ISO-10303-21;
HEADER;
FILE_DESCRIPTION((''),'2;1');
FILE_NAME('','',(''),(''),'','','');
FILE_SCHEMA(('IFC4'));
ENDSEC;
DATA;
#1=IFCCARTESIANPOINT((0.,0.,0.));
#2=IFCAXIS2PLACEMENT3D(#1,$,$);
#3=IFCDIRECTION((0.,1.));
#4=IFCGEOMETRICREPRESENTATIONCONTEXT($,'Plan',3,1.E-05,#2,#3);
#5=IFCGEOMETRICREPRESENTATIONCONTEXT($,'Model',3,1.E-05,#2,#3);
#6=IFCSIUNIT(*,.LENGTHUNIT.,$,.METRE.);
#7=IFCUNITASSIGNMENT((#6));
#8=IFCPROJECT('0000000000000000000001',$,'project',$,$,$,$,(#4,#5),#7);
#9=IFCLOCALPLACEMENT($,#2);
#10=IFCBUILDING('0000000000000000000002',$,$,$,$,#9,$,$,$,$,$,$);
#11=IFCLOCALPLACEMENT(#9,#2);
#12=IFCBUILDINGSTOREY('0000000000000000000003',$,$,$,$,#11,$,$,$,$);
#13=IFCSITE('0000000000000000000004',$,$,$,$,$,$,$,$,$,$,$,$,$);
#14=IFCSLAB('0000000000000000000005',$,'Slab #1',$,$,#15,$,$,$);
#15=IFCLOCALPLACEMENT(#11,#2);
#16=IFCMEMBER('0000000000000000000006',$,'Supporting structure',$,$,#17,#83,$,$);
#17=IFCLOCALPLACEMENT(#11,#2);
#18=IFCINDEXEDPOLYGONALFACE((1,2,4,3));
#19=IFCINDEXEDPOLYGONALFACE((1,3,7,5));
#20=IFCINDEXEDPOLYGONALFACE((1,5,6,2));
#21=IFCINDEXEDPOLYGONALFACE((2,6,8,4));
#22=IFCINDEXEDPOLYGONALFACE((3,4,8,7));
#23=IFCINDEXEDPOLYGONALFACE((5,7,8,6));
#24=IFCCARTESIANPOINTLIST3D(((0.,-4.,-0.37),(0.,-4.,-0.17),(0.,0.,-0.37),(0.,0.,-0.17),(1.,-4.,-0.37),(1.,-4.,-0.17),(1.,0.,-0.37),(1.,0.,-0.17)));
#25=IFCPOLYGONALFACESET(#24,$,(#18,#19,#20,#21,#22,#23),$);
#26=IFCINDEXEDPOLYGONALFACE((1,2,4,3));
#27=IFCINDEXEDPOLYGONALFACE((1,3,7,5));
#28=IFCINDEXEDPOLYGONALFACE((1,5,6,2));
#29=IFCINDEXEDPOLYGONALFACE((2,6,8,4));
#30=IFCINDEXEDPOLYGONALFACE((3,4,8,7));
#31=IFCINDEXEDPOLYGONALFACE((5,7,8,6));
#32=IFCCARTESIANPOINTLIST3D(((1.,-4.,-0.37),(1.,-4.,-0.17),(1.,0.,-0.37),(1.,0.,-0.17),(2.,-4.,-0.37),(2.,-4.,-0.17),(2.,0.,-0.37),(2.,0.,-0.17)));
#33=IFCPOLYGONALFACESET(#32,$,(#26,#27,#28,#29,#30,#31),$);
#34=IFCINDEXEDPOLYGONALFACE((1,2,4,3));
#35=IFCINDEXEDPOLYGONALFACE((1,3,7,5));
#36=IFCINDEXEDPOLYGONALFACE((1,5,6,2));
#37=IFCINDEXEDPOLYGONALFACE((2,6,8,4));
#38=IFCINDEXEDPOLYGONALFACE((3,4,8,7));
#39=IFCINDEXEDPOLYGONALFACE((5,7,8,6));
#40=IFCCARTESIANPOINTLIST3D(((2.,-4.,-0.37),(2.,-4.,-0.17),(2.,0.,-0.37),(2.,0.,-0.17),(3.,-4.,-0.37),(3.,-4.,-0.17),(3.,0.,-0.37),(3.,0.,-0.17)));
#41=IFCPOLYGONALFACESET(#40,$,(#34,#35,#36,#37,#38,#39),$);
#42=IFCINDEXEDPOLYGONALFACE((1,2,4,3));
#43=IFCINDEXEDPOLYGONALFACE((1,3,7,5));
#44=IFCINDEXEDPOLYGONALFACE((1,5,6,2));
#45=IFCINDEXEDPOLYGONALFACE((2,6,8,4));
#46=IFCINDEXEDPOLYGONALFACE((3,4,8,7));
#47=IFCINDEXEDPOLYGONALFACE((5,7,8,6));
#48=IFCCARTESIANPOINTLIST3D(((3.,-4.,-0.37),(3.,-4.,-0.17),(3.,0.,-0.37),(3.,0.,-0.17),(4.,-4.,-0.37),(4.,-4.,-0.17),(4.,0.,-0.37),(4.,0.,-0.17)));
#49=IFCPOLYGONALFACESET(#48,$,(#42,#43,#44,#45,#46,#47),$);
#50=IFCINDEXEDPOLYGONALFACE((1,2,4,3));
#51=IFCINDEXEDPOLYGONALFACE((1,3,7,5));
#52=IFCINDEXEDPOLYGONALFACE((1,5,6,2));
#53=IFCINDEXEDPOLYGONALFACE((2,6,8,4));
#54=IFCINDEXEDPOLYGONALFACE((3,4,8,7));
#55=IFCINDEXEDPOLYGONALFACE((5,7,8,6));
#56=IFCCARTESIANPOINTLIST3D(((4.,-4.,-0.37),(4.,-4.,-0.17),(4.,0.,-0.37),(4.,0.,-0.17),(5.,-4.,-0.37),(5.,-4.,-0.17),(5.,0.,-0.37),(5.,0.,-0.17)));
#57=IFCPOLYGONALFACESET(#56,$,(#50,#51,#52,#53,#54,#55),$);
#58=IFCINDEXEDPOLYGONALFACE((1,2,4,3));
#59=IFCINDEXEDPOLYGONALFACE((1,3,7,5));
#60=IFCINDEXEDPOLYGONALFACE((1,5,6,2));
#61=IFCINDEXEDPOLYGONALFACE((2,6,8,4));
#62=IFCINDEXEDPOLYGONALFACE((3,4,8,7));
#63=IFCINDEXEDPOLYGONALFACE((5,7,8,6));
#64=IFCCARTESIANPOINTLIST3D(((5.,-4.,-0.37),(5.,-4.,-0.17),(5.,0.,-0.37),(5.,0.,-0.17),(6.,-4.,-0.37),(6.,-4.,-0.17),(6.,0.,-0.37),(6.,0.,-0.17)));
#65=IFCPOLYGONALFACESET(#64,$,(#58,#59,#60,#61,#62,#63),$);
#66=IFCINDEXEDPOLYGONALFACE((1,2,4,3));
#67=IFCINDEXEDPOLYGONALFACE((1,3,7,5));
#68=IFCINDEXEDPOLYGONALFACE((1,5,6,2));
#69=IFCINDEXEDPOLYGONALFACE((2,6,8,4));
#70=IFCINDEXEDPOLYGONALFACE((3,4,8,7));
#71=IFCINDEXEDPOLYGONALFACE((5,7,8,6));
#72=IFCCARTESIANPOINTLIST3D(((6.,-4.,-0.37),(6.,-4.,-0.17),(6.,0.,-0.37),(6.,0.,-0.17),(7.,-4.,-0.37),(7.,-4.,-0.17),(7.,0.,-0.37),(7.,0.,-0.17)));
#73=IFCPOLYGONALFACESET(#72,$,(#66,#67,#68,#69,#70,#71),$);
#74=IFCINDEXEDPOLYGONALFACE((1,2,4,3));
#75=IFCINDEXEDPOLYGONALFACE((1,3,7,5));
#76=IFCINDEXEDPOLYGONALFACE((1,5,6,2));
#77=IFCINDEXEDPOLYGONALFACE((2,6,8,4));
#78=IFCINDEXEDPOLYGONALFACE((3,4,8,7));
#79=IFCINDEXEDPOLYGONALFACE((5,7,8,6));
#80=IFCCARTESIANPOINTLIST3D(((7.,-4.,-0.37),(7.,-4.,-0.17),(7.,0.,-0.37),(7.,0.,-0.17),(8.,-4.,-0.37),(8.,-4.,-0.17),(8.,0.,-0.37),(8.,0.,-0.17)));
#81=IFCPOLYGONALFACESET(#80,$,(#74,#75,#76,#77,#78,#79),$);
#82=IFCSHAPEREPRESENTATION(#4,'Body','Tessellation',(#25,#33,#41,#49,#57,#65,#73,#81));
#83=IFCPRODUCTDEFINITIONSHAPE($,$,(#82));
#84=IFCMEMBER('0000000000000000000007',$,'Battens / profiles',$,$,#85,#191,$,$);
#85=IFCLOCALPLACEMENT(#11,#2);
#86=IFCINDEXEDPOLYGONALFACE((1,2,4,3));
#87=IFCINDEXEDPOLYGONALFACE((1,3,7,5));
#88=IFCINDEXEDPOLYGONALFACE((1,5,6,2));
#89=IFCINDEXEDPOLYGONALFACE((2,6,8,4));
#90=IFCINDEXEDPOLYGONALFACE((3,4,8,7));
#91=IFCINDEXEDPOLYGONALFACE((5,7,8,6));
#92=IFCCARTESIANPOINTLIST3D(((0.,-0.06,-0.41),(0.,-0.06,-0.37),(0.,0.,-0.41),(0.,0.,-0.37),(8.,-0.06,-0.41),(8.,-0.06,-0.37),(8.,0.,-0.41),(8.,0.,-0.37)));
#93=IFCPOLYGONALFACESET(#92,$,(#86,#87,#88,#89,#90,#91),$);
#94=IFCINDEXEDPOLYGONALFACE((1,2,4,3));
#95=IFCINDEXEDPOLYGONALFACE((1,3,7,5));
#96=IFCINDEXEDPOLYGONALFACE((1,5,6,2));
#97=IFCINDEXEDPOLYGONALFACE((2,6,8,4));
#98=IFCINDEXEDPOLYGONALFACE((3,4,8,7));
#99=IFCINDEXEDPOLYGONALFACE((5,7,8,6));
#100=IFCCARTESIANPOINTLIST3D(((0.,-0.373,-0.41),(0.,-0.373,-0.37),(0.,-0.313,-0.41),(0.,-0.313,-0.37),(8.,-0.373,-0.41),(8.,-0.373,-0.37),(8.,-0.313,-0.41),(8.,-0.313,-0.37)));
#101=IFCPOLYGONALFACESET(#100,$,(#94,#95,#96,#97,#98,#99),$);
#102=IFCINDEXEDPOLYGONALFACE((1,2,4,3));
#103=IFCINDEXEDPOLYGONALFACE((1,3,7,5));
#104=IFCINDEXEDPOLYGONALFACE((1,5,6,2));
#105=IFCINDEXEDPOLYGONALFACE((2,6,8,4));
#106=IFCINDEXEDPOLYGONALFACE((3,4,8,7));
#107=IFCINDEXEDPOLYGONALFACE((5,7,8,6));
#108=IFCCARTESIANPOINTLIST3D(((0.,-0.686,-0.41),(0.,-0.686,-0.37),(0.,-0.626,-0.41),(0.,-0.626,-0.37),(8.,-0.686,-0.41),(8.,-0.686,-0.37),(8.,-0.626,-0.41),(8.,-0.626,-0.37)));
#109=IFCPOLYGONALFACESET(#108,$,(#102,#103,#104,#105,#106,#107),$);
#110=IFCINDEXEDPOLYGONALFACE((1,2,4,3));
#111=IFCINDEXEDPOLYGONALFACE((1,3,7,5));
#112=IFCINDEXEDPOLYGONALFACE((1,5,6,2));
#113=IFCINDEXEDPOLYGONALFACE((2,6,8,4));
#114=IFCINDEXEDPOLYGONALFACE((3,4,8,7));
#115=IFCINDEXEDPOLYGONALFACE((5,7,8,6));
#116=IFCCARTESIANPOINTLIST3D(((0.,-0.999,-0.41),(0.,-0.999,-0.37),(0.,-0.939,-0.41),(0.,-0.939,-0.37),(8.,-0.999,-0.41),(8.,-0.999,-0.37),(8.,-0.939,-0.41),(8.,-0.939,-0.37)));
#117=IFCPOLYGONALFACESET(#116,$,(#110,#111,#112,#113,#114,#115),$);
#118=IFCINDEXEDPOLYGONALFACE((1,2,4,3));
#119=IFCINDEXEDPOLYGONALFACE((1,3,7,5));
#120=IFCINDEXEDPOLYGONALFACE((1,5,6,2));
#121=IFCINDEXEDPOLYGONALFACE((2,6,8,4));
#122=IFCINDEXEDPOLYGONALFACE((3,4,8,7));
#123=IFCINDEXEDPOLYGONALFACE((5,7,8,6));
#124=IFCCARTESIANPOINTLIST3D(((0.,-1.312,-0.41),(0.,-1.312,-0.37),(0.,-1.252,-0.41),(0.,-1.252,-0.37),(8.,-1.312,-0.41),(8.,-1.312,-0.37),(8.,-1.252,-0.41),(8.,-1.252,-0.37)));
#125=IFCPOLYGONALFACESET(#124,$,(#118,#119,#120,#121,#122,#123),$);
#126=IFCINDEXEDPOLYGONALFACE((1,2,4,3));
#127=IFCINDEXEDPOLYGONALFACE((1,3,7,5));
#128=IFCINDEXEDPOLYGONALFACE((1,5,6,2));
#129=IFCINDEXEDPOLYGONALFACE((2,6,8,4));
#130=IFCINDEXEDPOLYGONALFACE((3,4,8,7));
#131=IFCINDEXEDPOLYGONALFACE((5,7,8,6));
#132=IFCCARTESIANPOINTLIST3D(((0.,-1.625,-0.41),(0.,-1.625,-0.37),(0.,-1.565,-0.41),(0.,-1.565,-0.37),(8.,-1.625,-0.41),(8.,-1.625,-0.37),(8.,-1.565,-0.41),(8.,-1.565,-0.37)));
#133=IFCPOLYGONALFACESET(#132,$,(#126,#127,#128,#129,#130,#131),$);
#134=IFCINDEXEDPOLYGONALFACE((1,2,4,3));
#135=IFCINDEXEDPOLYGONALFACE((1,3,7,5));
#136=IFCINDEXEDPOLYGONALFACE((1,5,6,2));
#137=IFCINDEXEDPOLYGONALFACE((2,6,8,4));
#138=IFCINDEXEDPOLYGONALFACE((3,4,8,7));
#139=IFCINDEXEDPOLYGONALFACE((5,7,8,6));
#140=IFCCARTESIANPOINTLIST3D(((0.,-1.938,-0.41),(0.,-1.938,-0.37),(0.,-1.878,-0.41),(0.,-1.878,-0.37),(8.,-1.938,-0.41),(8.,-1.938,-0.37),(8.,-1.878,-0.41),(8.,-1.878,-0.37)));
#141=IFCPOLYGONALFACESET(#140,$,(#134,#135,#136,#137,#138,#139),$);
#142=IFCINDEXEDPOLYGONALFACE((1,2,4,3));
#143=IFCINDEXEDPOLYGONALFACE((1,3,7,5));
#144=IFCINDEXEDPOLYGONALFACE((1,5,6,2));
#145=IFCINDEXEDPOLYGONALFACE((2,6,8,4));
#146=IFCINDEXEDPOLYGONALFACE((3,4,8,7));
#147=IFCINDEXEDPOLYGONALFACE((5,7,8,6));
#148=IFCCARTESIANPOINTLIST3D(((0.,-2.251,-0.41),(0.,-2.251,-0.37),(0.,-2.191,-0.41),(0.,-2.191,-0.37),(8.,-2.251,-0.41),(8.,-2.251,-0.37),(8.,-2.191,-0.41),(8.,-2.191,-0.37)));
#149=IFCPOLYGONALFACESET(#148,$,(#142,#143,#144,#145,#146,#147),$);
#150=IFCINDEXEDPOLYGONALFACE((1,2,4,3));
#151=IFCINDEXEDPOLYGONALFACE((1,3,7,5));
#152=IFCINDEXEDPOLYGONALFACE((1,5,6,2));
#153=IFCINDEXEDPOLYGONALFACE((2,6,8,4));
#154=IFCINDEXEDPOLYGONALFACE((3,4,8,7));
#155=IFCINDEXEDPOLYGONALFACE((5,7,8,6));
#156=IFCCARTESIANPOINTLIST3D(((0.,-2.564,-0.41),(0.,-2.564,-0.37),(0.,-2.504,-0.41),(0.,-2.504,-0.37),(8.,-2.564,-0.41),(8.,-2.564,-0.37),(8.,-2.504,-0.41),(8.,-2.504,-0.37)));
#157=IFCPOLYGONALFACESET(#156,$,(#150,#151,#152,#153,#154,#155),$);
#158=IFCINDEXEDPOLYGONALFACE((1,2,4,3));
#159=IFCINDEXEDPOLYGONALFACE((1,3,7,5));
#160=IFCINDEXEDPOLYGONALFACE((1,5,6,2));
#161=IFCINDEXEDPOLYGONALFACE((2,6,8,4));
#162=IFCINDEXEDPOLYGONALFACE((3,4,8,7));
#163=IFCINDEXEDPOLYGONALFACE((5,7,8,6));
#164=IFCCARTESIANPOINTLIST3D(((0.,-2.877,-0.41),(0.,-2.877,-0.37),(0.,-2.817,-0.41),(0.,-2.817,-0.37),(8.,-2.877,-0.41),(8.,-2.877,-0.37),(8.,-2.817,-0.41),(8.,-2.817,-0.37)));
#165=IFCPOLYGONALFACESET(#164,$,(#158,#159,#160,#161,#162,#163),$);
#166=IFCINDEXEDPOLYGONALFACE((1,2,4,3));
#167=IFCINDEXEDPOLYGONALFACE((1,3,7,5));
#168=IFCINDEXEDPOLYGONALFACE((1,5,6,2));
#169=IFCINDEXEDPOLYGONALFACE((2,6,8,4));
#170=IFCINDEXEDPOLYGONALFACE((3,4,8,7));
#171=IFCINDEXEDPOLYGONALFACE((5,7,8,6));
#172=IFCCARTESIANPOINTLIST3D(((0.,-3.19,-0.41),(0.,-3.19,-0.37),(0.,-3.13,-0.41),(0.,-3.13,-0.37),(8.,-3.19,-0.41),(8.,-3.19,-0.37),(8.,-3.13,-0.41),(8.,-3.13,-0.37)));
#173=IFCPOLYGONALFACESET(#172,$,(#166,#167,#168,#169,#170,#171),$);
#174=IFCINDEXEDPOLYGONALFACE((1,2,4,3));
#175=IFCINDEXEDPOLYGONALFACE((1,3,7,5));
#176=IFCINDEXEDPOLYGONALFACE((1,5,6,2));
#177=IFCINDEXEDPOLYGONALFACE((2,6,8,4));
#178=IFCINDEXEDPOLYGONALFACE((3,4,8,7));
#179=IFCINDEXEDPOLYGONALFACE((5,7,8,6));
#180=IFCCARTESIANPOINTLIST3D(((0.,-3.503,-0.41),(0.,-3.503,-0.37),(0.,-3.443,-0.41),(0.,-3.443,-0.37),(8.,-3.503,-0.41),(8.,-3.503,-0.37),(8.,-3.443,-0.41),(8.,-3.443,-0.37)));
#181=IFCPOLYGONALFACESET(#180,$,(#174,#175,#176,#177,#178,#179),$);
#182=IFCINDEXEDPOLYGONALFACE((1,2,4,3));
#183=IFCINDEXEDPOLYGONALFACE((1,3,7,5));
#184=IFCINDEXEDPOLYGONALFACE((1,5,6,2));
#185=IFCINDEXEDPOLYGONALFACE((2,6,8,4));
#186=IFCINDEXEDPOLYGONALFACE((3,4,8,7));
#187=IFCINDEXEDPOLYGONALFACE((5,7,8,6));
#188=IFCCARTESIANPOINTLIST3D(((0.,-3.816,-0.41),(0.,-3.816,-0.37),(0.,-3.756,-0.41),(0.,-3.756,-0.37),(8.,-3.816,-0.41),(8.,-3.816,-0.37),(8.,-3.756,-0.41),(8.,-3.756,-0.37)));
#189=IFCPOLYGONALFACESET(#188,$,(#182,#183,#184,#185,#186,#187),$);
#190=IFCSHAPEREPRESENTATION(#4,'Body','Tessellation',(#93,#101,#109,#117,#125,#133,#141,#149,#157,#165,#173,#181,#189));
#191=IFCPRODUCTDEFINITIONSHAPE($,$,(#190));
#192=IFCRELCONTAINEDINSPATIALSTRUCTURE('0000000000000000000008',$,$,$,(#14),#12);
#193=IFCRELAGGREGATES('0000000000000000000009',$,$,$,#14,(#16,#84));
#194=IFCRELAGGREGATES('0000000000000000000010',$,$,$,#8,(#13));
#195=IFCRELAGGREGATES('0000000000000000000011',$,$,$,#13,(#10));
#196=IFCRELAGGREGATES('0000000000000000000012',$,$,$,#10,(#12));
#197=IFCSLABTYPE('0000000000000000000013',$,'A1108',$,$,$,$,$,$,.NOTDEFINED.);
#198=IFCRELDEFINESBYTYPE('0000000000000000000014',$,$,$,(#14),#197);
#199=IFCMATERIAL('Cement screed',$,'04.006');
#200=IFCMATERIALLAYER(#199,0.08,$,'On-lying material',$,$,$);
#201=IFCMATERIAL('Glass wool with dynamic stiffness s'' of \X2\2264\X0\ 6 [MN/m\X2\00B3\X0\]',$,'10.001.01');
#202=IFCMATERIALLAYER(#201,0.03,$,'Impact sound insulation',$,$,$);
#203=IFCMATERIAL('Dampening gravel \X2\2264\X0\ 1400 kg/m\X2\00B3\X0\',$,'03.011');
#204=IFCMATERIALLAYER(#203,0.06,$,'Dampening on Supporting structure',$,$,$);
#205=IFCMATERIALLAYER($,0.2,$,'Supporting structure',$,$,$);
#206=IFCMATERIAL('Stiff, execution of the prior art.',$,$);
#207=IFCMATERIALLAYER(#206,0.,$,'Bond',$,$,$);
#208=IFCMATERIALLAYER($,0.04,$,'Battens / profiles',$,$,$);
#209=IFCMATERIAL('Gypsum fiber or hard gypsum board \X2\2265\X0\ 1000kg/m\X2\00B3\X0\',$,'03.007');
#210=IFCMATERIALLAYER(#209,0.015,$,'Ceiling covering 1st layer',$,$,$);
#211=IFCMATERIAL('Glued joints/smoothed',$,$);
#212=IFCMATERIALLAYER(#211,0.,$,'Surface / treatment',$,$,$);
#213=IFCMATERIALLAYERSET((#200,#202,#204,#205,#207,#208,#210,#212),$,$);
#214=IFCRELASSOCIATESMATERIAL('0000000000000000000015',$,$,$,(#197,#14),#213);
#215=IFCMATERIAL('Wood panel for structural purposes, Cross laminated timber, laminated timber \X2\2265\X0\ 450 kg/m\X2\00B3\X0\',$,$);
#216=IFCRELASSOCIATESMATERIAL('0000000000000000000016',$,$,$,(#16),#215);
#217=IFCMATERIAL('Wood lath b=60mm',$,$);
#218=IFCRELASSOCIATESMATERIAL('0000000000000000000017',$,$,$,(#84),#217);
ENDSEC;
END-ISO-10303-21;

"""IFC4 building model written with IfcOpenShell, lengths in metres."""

from ifc_helpers import new_model, si_unit, direction, frame, frame_2d, origin, place, context, project, spatial, rectangle, extrude, material, layer, layer_set, type_object, element, aggregate, save


model = new_model("IFC4")

# Units and contexts
plan_context = context("Plan", 3, precision=1e-05, world=origin(), true_north=direction((0.0, 1.0)))
model_context = context("Model", 3, precision=1e-05, world=origin(), true_north=direction((0.0, 1.0)))
ifc_project = project(units=[si_unit("LENGTHUNIT", "METRE")], contexts=[plan_context, model_context])

# Site, building, storey
site = spatial("IfcSite", under=ifc_project)
building_placement = place(None, origin())
building = spatial("IfcBuilding", under=site, at=building_placement)
storey_placement = place(building_placement, origin())
storey = spatial("IfcBuildingStorey", under=building, at=storey_placement)

# Slab, members
ifc_material_1 = material(Name="Cement screed", Category="04.006")
ifc_layer_1 = layer(ifc_material_1, 0.08, Name="On-lying material")
ifc_material_2 = material(Name="Glass wool with dynamic stiffness s' of ≤ 6 [MN/m³]", Category="10.001.01")
ifc_layer_2 = layer(ifc_material_2, 0.03, Name="Impact sound insulation")
ifc_material_3 = material(Name="Dampening gravel ≤ 1400 kg/m³", Category="03.011")
ifc_layer_3 = layer(ifc_material_3, 0.06, Name="Dampening on Supporting structure")
ifc_layer_4 = layer(None, 0.2, Name="Supporting structure")
ifc_material_4 = material(Name="Stiff, execution of the prior art.")
ifc_layer_5 = layer(ifc_material_4, 0.0, Name="Bond")
ifc_layer_6 = layer(None, 0.04, Name="Battens / profiles")
ifc_material_5 = material(Name="Gypsum fiber or hard gypsum board ≥ 1000kg/m³", Category="03.007")
ifc_layer_7 = layer(ifc_material_5, 0.015, Name="Ceiling covering 1st layer")
ifc_material_6 = material(Name="Glued joints/smoothed")
ifc_layer_8 = layer(ifc_material_6, 0.0, Name="Surface / treatment")
ifc_layer_set = layer_set([ifc_layer_1, ifc_layer_2, ifc_layer_3, ifc_layer_4, ifc_layer_5, ifc_layer_6, ifc_layer_7, ifc_layer_8])
slab_type = type_object("IfcSlabType", Name="A1108", PredefinedType="NOTDEFINED", material=ifc_layer_set)
slab_placement = place(None, frame((0.0, 0.0, 0.0), z_axis=(0.0, 0.0, -1.0), x_axis=(1.0, 0.0, 0.0)))
slab = element("IfcSlab", 1, at=slab_placement, inside=storey, type_object=slab_type, material=ifc_layer_set, Name="Slab #1")
ifc_material_7 = material(Name="Wood panel for structural purposes, Cross laminated timber, laminated timber ≥ 450 kg/m³")
member_1_placement = place(slab_placement, origin())
member_1 = element("IfcMember", 2, at=member_1_placement, material=ifc_material_7, Name="Supporting structure", context=plan_context, shape_type="SweptSolid", body=[
    extrude(rectangle(XDim=1.0, YDim=0.2, at=frame_2d((0.5, 0.1), x_axis=(1.0, 0.0))), frame((0.0, 4.0, 0.17), z_axis=(0.0, -1.0, 0.0), x_axis=(1.0, 0.0, 0.0)), (0.0, 0.0, 1.0), 4.0),
    extrude(rectangle(XDim=1.0, YDim=0.2, at=frame_2d((0.5, 0.1), x_axis=(1.0, 0.0))), frame((1.0, 4.0, 0.17), z_axis=(0.0, -1.0, 0.0), x_axis=(1.0, 0.0, 0.0)), (0.0, 0.0, 1.0), 4.0),
    extrude(rectangle(XDim=1.0, YDim=0.2, at=frame_2d((0.5, 0.1), x_axis=(1.0, 0.0))), frame((2.0, 4.0, 0.17), z_axis=(0.0, -1.0, 0.0), x_axis=(1.0, 0.0, 0.0)), (0.0, 0.0, 1.0), 4.0),
    extrude(rectangle(XDim=1.0, YDim=0.2, at=frame_2d((0.5, 0.1), x_axis=(1.0, 0.0))), frame((3.0, 4.0, 0.17), z_axis=(0.0, -1.0, 0.0), x_axis=(1.0, 0.0, 0.0)), (0.0, 0.0, 1.0), 4.0),
    extrude(rectangle(XDim=1.0, YDim=0.2, at=frame_2d((0.5, 0.1), x_axis=(1.0, 0.0))), frame((4.0, 4.0, 0.17), z_axis=(0.0, -1.0, 0.0), x_axis=(1.0, 0.0, 0.0)), (0.0, 0.0, 1.0), 4.0),
    extrude(rectangle(XDim=1.0, YDim=0.2, at=frame_2d((0.5, 0.1), x_axis=(1.0, 0.0))), frame((5.0, 4.0, 0.17), z_axis=(0.0, -1.0, 0.0), x_axis=(1.0, 0.0, 0.0)), (0.0, 0.0, 1.0), 4.0),
    extrude(rectangle(XDim=1.0, YDim=0.2, at=frame_2d((0.5, 0.1), x_axis=(1.0, 0.0))), frame((6.0, 4.0, 0.17), z_axis=(0.0, -1.0, 0.0), x_axis=(1.0, 0.0, 0.0)), (0.0, 0.0, 1.0), 4.0),
    extrude(rectangle(XDim=1.0, YDim=0.2, at=frame_2d((0.5, 0.1), x_axis=(1.0, 0.0))), frame((7.0, 4.0, 0.17), z_axis=(0.0, -1.0, 0.0), x_axis=(1.0, 0.0, 0.0)), (0.0, 0.0, 1.0), 4.0),
])
ifc_material_8 = material(Name="Wood lath b=60mm")
member_2_placement = place(slab_placement, origin())
member_2 = element("IfcMember", 3, at=member_2_placement, material=ifc_material_8, Name="Battens / profiles", context=plan_context, shape_type="SweptSolid", body=[
    extrude(rectangle(XDim=0.06, YDim=0.04, at=frame_2d((0.03, 0.02), x_axis=(1.0, 0.0))), frame((0.0, 0.0, 0.37), z_axis=(1.0, 0.0, 0.0), x_axis=(0.0, 1.0, 0.0)), (0.0, 0.0, 1.0), 8.0),
    extrude(rectangle(XDim=0.06, YDim=0.04, at=frame_2d((0.03, 0.02), x_axis=(1.0, 0.0))), frame((0.0, 0.313, 0.37), z_axis=(1.0, 0.0, 0.0), x_axis=(0.0, 1.0, 0.0)), (0.0, 0.0, 1.0), 8.0),
    extrude(rectangle(XDim=0.06, YDim=0.04, at=frame_2d((0.03, 0.02), x_axis=(1.0, 0.0))), frame((0.0, 0.626, 0.37), z_axis=(1.0, 0.0, 0.0), x_axis=(0.0, 1.0, 0.0)), (0.0, 0.0, 1.0), 8.0),
    extrude(rectangle(XDim=0.06, YDim=0.04, at=frame_2d((0.03, 0.02), x_axis=(1.0, 0.0))), frame((0.0, 0.939, 0.37), z_axis=(1.0, 0.0, 0.0), x_axis=(0.0, 1.0, 0.0)), (0.0, 0.0, 1.0), 8.0),
    extrude(rectangle(XDim=0.06, YDim=0.04, at=frame_2d((0.03, 0.02), x_axis=(1.0, 0.0))), frame((0.0, 1.252, 0.37), z_axis=(1.0, 0.0, 0.0), x_axis=(0.0, 1.0, 0.0)), (0.0, 0.0, 1.0), 8.0),
    extrude(rectangle(XDim=0.06, YDim=0.04, at=frame_2d((0.03, 0.02), x_axis=(1.0, 0.0))), frame((0.0, 1.565, 0.37), z_axis=(1.0, 0.0, 0.0), x_axis=(0.0, 1.0, 0.0)), (0.0, 0.0, 1.0), 8.0),
    extrude(rectangle(XDim=0.06, YDim=0.04, at=frame_2d((0.03, 0.02), x_axis=(1.0, 0.0))), frame((0.0, 1.878, 0.37), z_axis=(1.0, 0.0, 0.0), x_axis=(0.0, 1.0, 0.0)), (0.0, 0.0, 1.0), 8.0),
    extrude(rectangle(XDim=0.06, YDim=0.04, at=frame_2d((0.03, 0.02), x_axis=(1.0, 0.0))), frame((0.0, 2.191, 0.37), z_axis=(1.0, 0.0, 0.0), x_axis=(0.0, 1.0, 0.0)), (0.0, 0.0, 1.0), 8.0),
    extrude(rectangle(XDim=0.06, YDim=0.04, at=frame_2d((0.03, 0.02), x_axis=(1.0, 0.0))), frame((0.0, 2.504, 0.37), z_axis=(1.0, 0.0, 0.0), x_axis=(0.0, 1.0, 0.0)), (0.0, 0.0, 1.0), 8.0),
    extrude(rectangle(XDim=0.06, YDim=0.04, at=frame_2d((0.03, 0.02), x_axis=(1.0, 0.0))), frame((0.0, 2.817, 0.37), z_axis=(1.0, 0.0, 0.0), x_axis=(0.0, 1.0, 0.0)), (0.0, 0.0, 1.0), 8.0),
    extrude(rectangle(XDim=0.06, YDim=0.04, at=frame_2d((0.03, 0.02), x_axis=(1.0, 0.0))), frame((0.0, 3.13, 0.37), z_axis=(1.0, 0.0, 0.0), x_axis=(0.0, 1.0, 0.0)), (0.0, 0.0, 1.0), 8.0),
    extrude(rectangle(XDim=0.06, YDim=0.04, at=frame_2d((0.03, 0.02), x_axis=(1.0, 0.0))), frame((0.0, 3.443, 0.37), z_axis=(1.0, 0.0, 0.0), x_axis=(0.0, 1.0, 0.0)), (0.0, 0.0, 1.0), 8.0),
    extrude(rectangle(XDim=0.06, YDim=0.04, at=frame_2d((0.03, 0.02), x_axis=(1.0, 0.0))), frame((0.0, 3.756, 0.37), z_axis=(1.0, 0.0, 0.0), x_axis=(0.0, 1.0, 0.0)), (0.0, 0.0, 1.0), 8.0),
])
aggregate(slab, [member_1, member_2])

save(model, "model.ifc")
